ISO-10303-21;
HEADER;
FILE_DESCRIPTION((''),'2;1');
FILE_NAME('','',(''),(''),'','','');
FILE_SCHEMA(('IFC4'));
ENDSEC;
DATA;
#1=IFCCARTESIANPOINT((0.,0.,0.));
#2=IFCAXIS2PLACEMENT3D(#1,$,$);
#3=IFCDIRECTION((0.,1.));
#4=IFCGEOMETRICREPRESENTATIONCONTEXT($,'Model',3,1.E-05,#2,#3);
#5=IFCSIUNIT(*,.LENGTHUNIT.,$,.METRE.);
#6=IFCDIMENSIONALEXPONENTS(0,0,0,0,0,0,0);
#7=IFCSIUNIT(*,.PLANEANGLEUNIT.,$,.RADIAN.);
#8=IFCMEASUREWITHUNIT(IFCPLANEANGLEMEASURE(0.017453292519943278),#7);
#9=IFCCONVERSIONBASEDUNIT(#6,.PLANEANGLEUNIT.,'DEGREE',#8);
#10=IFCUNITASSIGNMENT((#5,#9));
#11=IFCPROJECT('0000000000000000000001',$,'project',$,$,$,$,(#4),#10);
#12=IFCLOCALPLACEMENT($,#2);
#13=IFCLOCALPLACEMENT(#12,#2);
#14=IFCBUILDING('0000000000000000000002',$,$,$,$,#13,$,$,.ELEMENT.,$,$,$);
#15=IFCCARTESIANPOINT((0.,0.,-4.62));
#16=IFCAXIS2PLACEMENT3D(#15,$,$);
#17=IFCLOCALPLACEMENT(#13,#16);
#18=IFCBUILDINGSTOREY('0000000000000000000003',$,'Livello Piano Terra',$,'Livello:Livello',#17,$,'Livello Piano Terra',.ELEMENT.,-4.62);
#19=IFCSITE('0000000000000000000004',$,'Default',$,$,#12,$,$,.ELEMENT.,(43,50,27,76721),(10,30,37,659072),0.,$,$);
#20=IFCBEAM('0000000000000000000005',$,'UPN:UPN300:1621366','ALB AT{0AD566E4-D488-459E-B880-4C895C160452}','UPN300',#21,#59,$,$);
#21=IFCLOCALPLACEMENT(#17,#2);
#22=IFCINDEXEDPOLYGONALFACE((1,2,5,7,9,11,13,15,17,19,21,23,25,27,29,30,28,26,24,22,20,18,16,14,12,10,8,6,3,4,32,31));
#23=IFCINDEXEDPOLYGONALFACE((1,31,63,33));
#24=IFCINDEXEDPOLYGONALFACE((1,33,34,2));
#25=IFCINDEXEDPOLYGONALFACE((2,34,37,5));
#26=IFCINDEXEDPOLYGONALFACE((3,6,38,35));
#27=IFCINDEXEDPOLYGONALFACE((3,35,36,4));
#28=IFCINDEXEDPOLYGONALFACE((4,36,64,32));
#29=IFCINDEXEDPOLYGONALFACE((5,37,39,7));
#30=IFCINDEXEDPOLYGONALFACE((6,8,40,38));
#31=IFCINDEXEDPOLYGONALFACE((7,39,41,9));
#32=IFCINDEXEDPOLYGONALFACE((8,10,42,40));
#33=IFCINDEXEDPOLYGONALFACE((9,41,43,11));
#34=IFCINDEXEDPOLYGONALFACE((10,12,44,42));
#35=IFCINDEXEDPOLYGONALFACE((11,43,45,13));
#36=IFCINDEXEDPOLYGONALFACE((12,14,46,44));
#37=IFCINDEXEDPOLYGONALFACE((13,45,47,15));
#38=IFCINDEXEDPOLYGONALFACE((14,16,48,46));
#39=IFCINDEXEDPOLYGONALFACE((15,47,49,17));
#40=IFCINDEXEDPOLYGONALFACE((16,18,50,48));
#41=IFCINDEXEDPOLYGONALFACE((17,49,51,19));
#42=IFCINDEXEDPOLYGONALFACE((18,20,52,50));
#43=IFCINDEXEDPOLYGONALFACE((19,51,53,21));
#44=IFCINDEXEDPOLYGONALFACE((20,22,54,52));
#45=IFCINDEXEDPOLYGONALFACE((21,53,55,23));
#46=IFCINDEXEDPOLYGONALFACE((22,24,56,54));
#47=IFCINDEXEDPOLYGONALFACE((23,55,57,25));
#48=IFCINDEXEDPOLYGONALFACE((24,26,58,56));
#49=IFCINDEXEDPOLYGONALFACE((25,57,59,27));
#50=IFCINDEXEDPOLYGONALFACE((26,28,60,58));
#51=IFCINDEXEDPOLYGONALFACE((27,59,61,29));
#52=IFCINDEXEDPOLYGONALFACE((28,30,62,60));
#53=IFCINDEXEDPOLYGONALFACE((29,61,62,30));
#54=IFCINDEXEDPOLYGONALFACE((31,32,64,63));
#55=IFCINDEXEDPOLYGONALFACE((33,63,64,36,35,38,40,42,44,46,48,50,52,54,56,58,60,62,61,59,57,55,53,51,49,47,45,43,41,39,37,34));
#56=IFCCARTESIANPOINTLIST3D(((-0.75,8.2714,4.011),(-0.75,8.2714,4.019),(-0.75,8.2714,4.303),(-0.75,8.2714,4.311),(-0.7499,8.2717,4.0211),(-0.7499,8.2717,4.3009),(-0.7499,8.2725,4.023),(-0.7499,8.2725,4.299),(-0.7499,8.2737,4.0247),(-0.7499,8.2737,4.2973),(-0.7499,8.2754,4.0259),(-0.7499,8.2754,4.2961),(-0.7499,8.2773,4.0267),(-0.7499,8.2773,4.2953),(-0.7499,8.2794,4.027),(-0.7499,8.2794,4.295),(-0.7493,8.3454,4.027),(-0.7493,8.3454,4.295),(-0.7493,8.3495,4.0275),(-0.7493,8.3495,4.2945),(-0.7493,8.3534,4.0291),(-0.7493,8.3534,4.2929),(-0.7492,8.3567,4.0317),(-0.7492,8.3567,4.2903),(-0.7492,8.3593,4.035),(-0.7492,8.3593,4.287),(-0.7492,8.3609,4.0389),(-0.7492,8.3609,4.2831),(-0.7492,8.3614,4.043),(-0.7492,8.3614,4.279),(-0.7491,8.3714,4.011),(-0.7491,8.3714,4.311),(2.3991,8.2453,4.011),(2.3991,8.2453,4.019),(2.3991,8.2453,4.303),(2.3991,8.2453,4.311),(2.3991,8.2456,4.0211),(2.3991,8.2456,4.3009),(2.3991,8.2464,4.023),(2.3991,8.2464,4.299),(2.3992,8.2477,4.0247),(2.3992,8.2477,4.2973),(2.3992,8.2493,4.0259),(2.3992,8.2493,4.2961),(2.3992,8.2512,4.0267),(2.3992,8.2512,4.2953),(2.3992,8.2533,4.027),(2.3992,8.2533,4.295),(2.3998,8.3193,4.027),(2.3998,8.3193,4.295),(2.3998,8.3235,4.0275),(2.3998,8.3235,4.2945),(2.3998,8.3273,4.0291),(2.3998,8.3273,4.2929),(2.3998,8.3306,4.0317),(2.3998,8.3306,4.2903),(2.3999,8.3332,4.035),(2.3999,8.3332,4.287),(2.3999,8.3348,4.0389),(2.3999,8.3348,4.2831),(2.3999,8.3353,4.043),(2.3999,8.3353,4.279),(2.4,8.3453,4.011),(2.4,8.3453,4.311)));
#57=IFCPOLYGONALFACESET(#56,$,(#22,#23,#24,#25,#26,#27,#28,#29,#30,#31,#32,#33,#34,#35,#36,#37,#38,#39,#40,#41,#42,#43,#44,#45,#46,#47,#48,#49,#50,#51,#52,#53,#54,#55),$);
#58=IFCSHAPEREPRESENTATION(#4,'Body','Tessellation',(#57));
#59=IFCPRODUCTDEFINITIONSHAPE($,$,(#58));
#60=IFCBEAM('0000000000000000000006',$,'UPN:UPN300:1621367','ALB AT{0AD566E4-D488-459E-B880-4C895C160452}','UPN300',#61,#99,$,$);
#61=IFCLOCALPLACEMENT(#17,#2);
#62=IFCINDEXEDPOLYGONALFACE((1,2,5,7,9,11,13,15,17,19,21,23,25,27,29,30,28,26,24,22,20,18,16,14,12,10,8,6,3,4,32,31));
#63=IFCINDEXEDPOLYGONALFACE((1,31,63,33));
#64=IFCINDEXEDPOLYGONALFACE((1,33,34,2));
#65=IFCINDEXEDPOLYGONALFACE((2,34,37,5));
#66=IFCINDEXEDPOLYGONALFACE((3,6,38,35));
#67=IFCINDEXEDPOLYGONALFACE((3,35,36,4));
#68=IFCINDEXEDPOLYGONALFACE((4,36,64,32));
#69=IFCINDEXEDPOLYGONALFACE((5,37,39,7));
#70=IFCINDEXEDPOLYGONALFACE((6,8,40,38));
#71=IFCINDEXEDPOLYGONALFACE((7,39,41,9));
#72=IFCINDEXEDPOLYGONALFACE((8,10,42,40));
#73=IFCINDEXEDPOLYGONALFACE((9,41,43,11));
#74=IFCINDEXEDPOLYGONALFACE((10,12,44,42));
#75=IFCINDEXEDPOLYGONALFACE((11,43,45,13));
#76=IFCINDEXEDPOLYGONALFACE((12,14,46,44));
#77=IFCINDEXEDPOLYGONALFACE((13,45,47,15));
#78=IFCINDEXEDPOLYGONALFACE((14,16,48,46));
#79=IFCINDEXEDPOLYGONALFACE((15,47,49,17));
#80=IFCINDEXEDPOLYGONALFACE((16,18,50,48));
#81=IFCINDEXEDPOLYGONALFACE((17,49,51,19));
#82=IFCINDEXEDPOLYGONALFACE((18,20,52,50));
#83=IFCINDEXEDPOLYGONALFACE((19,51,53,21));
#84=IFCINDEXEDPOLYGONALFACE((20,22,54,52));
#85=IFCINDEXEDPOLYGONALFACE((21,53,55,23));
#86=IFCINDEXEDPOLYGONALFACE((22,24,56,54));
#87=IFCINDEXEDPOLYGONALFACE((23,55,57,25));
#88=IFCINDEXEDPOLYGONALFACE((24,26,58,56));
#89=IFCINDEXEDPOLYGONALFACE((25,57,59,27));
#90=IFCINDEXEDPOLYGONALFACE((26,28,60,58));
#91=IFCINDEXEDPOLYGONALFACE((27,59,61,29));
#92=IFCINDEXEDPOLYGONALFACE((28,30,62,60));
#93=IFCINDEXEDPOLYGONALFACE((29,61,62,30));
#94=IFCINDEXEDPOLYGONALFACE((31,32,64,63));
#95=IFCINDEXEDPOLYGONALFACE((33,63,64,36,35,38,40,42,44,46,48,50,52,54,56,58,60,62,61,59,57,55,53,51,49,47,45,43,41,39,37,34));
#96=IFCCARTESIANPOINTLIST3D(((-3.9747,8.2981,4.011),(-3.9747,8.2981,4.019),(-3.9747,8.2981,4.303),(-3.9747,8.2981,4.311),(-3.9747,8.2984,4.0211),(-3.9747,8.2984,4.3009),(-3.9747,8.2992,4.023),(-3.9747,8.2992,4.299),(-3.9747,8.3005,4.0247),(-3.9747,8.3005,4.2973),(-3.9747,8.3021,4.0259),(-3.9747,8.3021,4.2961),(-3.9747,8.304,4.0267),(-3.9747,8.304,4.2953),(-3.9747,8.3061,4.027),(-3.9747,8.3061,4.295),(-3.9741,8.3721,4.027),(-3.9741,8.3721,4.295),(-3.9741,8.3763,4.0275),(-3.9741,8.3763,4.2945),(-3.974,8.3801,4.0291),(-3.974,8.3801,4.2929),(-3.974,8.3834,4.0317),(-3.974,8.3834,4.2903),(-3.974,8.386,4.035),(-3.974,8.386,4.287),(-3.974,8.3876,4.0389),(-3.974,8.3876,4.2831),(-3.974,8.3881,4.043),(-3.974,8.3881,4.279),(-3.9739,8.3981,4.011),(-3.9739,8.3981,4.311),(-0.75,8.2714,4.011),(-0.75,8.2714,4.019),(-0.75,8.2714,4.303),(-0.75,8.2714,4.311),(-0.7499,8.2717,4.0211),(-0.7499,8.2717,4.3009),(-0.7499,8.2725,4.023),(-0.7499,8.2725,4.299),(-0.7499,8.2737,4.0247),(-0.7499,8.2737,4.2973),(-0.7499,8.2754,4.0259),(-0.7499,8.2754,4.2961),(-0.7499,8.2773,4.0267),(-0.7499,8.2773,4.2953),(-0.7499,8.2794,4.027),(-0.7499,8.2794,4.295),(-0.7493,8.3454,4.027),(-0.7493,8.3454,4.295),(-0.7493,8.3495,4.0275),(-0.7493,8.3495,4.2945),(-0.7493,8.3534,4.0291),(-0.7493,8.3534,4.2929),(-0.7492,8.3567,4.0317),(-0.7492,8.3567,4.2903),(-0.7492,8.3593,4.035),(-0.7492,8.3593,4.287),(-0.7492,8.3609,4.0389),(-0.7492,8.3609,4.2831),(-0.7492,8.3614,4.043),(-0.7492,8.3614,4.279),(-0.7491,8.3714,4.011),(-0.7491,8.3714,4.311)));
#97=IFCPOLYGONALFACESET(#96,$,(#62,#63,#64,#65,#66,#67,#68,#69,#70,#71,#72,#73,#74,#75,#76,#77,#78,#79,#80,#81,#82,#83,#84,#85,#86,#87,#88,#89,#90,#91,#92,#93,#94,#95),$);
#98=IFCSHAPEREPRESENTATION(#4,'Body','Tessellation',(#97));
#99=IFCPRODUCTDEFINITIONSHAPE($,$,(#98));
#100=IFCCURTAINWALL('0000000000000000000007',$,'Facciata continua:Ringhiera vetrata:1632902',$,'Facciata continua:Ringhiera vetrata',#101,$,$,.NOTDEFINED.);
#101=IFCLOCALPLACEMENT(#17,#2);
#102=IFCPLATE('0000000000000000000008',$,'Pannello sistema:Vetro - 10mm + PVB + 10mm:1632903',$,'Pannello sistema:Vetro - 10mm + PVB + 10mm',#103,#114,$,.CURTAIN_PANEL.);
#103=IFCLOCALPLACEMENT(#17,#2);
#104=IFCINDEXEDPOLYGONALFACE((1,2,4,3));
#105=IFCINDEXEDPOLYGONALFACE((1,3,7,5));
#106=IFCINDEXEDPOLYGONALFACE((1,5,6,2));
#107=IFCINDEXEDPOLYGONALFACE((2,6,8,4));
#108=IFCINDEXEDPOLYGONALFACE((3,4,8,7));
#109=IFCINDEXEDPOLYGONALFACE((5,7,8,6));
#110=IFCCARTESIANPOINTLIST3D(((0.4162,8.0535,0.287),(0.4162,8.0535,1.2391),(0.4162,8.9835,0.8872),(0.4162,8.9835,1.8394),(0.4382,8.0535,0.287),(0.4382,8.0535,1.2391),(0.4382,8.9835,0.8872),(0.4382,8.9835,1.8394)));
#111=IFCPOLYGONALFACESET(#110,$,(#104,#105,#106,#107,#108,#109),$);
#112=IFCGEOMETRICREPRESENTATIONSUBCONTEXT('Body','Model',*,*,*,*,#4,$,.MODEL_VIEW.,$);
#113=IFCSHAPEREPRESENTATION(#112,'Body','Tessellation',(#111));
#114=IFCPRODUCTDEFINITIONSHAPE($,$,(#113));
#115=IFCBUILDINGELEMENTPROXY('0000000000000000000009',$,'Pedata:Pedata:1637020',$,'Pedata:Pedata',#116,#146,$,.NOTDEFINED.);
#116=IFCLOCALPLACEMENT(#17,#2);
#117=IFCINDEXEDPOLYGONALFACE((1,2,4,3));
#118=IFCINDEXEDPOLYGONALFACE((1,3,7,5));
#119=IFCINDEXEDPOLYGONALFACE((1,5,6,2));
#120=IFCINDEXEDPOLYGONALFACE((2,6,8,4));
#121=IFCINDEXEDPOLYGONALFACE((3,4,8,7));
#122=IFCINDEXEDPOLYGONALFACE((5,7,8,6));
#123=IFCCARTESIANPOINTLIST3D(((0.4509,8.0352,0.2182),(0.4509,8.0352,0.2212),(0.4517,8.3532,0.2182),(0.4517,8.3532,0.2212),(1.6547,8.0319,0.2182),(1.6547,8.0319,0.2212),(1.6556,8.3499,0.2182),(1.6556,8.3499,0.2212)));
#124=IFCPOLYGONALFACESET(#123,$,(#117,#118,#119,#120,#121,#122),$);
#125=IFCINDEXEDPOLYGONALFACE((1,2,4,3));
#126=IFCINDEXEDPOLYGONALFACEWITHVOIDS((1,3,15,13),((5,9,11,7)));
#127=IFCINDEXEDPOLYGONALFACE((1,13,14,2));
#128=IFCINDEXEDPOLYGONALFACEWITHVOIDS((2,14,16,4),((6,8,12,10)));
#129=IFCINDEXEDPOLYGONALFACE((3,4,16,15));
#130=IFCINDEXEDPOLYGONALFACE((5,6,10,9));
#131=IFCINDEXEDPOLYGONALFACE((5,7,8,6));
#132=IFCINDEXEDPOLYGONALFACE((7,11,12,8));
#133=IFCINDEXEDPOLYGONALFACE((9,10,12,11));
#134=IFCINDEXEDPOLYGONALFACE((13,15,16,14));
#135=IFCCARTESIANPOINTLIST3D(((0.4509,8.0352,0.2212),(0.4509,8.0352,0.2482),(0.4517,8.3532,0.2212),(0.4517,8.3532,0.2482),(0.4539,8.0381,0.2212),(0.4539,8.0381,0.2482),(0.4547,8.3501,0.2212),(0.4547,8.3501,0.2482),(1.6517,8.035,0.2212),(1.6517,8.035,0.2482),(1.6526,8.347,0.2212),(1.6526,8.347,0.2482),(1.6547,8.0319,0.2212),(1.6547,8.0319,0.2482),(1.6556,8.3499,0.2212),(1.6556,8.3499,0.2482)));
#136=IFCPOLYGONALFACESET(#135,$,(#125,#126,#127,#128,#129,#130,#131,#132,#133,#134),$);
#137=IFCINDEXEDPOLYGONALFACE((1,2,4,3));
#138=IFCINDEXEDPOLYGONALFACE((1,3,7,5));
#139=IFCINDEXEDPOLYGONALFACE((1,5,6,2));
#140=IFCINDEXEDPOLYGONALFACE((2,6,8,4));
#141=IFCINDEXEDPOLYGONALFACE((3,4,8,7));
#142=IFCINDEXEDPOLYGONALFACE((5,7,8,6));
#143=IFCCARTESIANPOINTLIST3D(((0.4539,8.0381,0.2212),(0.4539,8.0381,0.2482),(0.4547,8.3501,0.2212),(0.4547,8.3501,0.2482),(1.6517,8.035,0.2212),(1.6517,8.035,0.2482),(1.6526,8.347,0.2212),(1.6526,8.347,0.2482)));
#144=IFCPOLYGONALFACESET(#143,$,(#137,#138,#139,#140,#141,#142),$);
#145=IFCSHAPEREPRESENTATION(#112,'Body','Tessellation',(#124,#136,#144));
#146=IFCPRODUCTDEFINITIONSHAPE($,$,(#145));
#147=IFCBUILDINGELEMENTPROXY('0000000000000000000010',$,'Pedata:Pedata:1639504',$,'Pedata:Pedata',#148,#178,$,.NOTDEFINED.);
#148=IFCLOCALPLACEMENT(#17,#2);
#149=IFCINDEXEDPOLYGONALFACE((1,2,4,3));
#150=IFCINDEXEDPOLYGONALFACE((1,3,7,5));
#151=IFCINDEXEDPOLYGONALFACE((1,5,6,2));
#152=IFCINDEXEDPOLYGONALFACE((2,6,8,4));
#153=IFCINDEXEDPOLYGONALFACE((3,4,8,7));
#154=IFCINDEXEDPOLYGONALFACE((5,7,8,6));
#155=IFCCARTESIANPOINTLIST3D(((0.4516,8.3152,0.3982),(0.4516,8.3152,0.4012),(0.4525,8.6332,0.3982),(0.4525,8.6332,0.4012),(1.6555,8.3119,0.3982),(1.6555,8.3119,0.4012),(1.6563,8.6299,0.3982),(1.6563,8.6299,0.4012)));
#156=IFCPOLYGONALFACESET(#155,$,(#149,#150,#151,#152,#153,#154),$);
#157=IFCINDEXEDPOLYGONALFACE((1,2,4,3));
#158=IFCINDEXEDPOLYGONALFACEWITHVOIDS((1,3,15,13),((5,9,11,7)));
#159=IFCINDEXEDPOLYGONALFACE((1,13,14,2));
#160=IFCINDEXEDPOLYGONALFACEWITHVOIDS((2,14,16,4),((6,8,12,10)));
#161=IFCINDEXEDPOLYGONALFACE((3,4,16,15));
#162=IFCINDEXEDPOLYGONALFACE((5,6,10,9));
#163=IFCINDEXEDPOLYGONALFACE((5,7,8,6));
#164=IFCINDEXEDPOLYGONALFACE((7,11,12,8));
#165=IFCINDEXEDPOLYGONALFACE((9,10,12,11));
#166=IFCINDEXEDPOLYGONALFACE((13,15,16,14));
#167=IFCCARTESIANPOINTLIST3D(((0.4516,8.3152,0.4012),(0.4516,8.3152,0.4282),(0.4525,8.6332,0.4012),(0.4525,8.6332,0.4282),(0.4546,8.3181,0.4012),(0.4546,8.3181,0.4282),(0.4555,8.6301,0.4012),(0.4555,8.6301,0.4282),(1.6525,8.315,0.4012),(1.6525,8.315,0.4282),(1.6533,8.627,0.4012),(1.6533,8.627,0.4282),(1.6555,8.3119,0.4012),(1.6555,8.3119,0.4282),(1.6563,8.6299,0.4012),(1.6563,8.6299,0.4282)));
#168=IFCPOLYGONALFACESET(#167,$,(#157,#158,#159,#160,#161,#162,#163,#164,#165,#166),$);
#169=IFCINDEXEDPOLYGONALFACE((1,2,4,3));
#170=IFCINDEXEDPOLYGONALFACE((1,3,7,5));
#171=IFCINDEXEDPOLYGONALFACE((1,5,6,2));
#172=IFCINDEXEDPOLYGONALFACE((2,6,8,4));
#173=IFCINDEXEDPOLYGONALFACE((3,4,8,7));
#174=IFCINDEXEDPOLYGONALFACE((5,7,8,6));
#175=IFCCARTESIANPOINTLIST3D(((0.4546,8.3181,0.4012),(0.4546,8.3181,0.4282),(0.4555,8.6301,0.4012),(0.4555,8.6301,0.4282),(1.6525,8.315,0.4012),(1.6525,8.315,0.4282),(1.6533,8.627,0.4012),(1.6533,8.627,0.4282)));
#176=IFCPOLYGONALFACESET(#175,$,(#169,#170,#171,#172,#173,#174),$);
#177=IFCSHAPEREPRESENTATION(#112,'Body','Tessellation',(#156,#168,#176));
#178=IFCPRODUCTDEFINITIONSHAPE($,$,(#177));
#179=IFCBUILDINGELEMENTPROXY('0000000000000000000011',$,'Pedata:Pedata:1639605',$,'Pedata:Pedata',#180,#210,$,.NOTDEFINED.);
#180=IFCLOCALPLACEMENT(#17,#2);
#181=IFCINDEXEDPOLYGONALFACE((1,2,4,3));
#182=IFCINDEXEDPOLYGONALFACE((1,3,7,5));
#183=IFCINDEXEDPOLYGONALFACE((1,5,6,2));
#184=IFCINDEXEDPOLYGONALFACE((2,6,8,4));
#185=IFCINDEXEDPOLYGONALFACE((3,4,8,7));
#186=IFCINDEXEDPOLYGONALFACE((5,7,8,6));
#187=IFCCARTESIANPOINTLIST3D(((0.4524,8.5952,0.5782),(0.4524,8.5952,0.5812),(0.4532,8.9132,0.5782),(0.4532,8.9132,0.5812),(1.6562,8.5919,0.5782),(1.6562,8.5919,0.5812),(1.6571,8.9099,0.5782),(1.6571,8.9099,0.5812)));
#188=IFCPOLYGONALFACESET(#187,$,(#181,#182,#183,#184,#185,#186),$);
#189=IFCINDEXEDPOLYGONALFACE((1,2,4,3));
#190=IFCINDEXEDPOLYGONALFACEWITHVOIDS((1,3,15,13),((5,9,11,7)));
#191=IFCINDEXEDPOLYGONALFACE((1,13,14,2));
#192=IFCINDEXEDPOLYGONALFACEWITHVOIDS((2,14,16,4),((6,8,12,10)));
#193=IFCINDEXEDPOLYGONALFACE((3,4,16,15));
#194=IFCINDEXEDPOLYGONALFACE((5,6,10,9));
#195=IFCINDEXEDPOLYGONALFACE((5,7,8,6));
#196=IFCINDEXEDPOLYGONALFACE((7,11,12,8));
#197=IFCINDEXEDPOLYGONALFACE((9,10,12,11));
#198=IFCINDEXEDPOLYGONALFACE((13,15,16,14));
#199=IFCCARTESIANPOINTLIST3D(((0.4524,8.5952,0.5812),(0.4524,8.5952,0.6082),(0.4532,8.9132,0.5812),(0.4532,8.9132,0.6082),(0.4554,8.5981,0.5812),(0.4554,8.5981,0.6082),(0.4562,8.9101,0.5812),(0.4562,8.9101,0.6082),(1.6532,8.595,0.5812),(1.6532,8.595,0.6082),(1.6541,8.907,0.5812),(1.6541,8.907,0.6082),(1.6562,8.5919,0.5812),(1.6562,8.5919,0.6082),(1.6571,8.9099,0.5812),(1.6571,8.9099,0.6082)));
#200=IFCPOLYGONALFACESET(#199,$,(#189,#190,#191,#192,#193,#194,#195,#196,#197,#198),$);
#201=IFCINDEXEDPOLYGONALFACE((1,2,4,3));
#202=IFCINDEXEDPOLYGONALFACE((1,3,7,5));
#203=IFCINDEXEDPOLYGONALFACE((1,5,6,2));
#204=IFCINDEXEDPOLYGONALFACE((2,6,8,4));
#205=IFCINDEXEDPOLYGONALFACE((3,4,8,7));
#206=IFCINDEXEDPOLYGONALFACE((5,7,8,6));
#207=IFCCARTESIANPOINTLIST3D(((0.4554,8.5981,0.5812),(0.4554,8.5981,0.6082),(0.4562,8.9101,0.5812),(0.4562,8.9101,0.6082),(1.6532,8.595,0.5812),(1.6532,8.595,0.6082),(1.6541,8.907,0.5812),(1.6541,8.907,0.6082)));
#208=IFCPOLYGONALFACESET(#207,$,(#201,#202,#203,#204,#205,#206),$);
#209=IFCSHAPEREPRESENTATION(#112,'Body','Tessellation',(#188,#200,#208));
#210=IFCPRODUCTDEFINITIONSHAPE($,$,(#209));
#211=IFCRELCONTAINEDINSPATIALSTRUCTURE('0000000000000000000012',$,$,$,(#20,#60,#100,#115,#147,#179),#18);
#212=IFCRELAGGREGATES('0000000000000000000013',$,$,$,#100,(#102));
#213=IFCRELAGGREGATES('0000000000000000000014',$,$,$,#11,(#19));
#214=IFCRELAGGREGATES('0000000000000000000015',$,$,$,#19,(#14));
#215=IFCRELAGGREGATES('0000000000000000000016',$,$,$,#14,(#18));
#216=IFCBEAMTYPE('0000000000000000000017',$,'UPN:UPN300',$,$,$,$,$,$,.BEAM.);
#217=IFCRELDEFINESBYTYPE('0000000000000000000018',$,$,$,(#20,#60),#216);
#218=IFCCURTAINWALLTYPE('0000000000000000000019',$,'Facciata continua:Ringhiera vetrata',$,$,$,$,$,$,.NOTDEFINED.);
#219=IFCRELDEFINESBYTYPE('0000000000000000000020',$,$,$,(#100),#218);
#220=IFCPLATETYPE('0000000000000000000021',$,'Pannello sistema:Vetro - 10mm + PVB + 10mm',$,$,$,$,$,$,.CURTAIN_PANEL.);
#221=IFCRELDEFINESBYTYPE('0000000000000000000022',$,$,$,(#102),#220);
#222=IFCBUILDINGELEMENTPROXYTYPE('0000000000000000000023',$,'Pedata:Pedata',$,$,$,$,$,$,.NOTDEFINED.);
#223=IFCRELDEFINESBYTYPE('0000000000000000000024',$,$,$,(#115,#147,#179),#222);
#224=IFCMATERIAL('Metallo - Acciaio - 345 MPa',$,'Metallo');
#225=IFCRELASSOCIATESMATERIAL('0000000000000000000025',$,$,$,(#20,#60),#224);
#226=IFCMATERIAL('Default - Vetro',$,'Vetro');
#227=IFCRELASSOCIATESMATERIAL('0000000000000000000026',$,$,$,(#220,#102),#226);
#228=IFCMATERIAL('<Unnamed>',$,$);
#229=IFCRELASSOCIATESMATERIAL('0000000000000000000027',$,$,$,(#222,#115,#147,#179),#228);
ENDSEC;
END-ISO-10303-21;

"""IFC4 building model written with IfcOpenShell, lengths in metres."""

from ifc_helpers import new_model, entity, si_unit, converted_unit, direction, frame, frame_2d, origin, place, context, subcontext, project, spatial, indexed_curve, u_section, outline, extrude, source, transform, mapped, material, type_object, type_shapes, element, aggregate, save


model = new_model("IFC4")

# Units and contexts
model_context = context("Model", 3, precision=1e-05, world=origin(), true_north=direction((0.0, 1.0)))
body_context = subcontext(model_context, "Body", "Model", "MODEL_VIEW")
ifc_project = project(units=[si_unit("LENGTHUNIT", "METRE"), converted_unit("PLANEANGLEUNIT", "DEGREE", entity("IfcPlaneAngleMeasure", 0.017453292519943278), si_unit("PLANEANGLEUNIT", "RADIAN"), dimensions=[0, 0, 0, 0, 0, 0, 0])], contexts=[model_context])

# Site, building, storey
site_placement = place(None, origin())
site = spatial("IfcSite", under=ifc_project, at=site_placement, Name="Default", CompositionType="ELEMENT", RefLatitude=(43, 50, 27, 76721), RefLongitude=(10, 30, 37, 659072), RefElevation=0.0)
building_placement = place(site_placement, origin())
building = spatial("IfcBuilding", under=site, at=building_placement, CompositionType="ELEMENT")
storey_placement = place(building_placement, frame((0.0, 0.0, -4.62)))
storey = spatial("IfcBuildingStorey", under=building, at=storey_placement, Name="Livello Piano Terra", ObjectType="Livello:Livello", LongName="Livello Piano Terra", CompositionType="ELEMENT", Elevation=-4.62)

# Shared definitions
ifc_material_1 = material(Name="Metallo - Acciaio - 345 MPa", Category="Metallo")

# Beams
beam_type_1 = type_object("IfcBeamType", Name="UPN:UPN300", PredefinedType="BEAM")
beam_1_placement = place(storey_placement, frame((2.3997, 8.3183, 4.161), z_axis=(-0.999966, 0.008283, 0.0), x_axis=(-0.008283, -0.999966, 0.0)))
element("IfcBeam", 1, at=beam_1_placement, inside=storey, type_object=beam_type_1, material=ifc_material_1, Name="UPN:UPN300:1621366", Description="ALB AT{0AD566E4-D488-459E-B880-4C895C160452}", ObjectType="UPN300", context=model_context, shape_type="SweptSolid", body=[
    extrude(u_section(Depth=0.3, FlangeWidth=0.1, WebThickness=0.01, FlangeThickness=0.016, FilletRadius=0.016, EdgeRadius=0.008, FlangeSlope=0.00457, at=frame_2d((0.023, 0.0))), origin(), (0.0, 0.0, 1.0), 3.1492),
])
beam_2_placement = place(storey_placement, frame((-0.7493, 8.3444, 4.161), z_axis=(-0.999966, 0.008283, 0.0), x_axis=(-0.008283, -0.999966, 0.0)))
element("IfcBeam", 2, at=beam_2_placement, inside=storey, type_object=beam_type_1, material=ifc_material_1, Name="UPN:UPN300:1621367", Description="ALB AT{0AD566E4-D488-459E-B880-4C895C160452}", ObjectType="UPN300", context=model_context, shape_type="SweptSolid", body=[
    extrude(u_section(Depth=0.3, FlangeWidth=0.1, WebThickness=0.01, FlangeThickness=0.016, FilletRadius=0.016, EdgeRadius=0.008, FlangeSlope=0.00457, at=frame_2d((0.023, 0.0))), origin(), (0.0, 0.0, 1.0), 3.2249),
])

# Curtain wall, plate
curtain_wall_type = type_object("IfcCurtainWallType", Name="Facciata continua:Ringhiera vetrata", PredefinedType="NOTDEFINED")
curtain_wall_1_placement = place(storey_placement, frame((0.0, 0.0, 4.62)))
curtain_wall_1 = element("IfcCurtainWall", 3, at=curtain_wall_1_placement, inside=storey, type_object=curtain_wall_type, Name="Facciata continua:Ringhiera vetrata:1632902", ObjectType="Facciata continua:Ringhiera vetrata", PredefinedType="NOTDEFINED")
ifc_material_2 = material(Name="Default - Vetro", Category="Vetro")
plate_type_1 = type_object("IfcPlateType", Name="Pannello sistema:Vetro - 10mm + PVB + 10mm", PredefinedType="CURTAIN_PANEL", material=ifc_material_2)
shared_shape_1 = source(origin(), body_context, "Body", "SweptSolid", [
    extrude(outline(indexed_curve([(-0.7762, -0.465), (0.176, -0.465), (0.7762, 0.465), (-0.176, 0.465), (-0.7762, -0.465)], self_intersect=False)), frame((0.0, -0.011, 0.7762), z_axis=(0.0, 1.0, 0.0), x_axis=(0.0, 0.0, 1.0)), (0.0, 0.0, 1.0), 0.022),
])
type_shapes(plate_type_1, [shared_shape_1])
plate_1_placement = place(curtain_wall_1_placement, frame((0.4272, 8.5185, -4.333), z_axis=(0.0, 0.0, 1.0), x_axis=(0.0, 1.0, 0.0)))
plate_1 = element("IfcPlate", 4, at=plate_1_placement, type_object=plate_type_1, material=ifc_material_2, Name="Pannello sistema:Vetro - 10mm + PVB + 10mm:1632903", ObjectType="Pannello sistema:Vetro - 10mm + PVB + 10mm", PredefinedType="CURTAIN_PANEL", context=body_context, shape_type="MappedRepresentation", body=[
    mapped(shared_shape_1, transform((0.0, 0.0, 0.0), scale=1.0)),
])
aggregate(curtain_wall_1, [plate_1])

# Building element proxies
ifc_material_3 = material(Name="<Unnamed>")
building_element_proxy_type = type_object("IfcBuildingElementProxyType", Name="Pedata:Pedata", PredefinedType="NOTDEFINED", material=ifc_material_3)
shared_shape_2 = source(origin(), body_context, "Body", "SweptSolid", [
    extrude(outline(indexed_curve([(-0.6019, -0.159), (0.6019, -0.159), (0.6019, 0.159), (-0.6019, 0.159), (-0.6019, -0.159)], self_intersect=False)), frame((0.0, 0.0015, -0.03), z_axis=(0.0, 0.0, 1.0), x_axis=(-1.0, 0.0, 0.0)), (0.0, 0.0, 1.0), 0.003),
    extrude(outline(indexed_curve([(-0.159, -0.6019), (0.159, -0.6019), (0.159, 0.6019), (-0.159, 0.6019), (-0.159, -0.6019)], self_intersect=False), holes=[indexed_curve([(0.156, -0.5989), (-0.156, -0.5989), (-0.156, 0.5989), (0.156, 0.5989), (0.156, -0.5989)], self_intersect=False)]), frame((0.0, 0.0015, -0.027), z_axis=(0.0, 0.0, 1.0), x_axis=(0.0, 1.0, 0.0)), (0.0, 0.0, 1.0), 0.027),
    extrude(outline(indexed_curve([(-0.5989, -0.156), (0.5989, -0.156), (0.5989, 0.156), (-0.5989, 0.156), (-0.5989, -0.156)], self_intersect=False)), frame((0.0, 0.0015, -0.027), z_axis=(0.0, 0.0, 1.0), x_axis=(-1.0, 0.0, 0.0)), (0.0, 0.0, 1.0), 0.027),
])
type_shapes(building_element_proxy_type, [shared_shape_2])
for number, where, z_axis, x_axis, name in (
    (5, (1.0532, 8.1911, 0.2482), (0.0, 0.0, 1.0), (0.999996, -0.002667, 0.0), "Pedata:Pedata:1637020"),
    (6, (1.054, 8.4711, 0.4282), (0.0, 0.0, 1.0), (0.999996, -0.002667, 0.0), "Pedata:Pedata:1639504"),
    (7, (1.0547, 8.751, 0.6082), (0.0, 0.0, 1.0), (0.999996, -0.002667, 0.0), "Pedata:Pedata:1639605"),
):
    element("IfcBuildingElementProxy", number, at=place(storey_placement, frame(where, z_axis=z_axis, x_axis=x_axis)), inside=storey, type_object=building_element_proxy_type, material=ifc_material_3, Name=name, ObjectType="Pedata:Pedata", PredefinedType="NOTDEFINED", context=body_context, shape_type="MappedRepresentation", body=[
        mapped(shared_shape_2, transform((0.0, 0.0, 0.0), scale=1.0)),
    ])

save(model, "model.ifc")
